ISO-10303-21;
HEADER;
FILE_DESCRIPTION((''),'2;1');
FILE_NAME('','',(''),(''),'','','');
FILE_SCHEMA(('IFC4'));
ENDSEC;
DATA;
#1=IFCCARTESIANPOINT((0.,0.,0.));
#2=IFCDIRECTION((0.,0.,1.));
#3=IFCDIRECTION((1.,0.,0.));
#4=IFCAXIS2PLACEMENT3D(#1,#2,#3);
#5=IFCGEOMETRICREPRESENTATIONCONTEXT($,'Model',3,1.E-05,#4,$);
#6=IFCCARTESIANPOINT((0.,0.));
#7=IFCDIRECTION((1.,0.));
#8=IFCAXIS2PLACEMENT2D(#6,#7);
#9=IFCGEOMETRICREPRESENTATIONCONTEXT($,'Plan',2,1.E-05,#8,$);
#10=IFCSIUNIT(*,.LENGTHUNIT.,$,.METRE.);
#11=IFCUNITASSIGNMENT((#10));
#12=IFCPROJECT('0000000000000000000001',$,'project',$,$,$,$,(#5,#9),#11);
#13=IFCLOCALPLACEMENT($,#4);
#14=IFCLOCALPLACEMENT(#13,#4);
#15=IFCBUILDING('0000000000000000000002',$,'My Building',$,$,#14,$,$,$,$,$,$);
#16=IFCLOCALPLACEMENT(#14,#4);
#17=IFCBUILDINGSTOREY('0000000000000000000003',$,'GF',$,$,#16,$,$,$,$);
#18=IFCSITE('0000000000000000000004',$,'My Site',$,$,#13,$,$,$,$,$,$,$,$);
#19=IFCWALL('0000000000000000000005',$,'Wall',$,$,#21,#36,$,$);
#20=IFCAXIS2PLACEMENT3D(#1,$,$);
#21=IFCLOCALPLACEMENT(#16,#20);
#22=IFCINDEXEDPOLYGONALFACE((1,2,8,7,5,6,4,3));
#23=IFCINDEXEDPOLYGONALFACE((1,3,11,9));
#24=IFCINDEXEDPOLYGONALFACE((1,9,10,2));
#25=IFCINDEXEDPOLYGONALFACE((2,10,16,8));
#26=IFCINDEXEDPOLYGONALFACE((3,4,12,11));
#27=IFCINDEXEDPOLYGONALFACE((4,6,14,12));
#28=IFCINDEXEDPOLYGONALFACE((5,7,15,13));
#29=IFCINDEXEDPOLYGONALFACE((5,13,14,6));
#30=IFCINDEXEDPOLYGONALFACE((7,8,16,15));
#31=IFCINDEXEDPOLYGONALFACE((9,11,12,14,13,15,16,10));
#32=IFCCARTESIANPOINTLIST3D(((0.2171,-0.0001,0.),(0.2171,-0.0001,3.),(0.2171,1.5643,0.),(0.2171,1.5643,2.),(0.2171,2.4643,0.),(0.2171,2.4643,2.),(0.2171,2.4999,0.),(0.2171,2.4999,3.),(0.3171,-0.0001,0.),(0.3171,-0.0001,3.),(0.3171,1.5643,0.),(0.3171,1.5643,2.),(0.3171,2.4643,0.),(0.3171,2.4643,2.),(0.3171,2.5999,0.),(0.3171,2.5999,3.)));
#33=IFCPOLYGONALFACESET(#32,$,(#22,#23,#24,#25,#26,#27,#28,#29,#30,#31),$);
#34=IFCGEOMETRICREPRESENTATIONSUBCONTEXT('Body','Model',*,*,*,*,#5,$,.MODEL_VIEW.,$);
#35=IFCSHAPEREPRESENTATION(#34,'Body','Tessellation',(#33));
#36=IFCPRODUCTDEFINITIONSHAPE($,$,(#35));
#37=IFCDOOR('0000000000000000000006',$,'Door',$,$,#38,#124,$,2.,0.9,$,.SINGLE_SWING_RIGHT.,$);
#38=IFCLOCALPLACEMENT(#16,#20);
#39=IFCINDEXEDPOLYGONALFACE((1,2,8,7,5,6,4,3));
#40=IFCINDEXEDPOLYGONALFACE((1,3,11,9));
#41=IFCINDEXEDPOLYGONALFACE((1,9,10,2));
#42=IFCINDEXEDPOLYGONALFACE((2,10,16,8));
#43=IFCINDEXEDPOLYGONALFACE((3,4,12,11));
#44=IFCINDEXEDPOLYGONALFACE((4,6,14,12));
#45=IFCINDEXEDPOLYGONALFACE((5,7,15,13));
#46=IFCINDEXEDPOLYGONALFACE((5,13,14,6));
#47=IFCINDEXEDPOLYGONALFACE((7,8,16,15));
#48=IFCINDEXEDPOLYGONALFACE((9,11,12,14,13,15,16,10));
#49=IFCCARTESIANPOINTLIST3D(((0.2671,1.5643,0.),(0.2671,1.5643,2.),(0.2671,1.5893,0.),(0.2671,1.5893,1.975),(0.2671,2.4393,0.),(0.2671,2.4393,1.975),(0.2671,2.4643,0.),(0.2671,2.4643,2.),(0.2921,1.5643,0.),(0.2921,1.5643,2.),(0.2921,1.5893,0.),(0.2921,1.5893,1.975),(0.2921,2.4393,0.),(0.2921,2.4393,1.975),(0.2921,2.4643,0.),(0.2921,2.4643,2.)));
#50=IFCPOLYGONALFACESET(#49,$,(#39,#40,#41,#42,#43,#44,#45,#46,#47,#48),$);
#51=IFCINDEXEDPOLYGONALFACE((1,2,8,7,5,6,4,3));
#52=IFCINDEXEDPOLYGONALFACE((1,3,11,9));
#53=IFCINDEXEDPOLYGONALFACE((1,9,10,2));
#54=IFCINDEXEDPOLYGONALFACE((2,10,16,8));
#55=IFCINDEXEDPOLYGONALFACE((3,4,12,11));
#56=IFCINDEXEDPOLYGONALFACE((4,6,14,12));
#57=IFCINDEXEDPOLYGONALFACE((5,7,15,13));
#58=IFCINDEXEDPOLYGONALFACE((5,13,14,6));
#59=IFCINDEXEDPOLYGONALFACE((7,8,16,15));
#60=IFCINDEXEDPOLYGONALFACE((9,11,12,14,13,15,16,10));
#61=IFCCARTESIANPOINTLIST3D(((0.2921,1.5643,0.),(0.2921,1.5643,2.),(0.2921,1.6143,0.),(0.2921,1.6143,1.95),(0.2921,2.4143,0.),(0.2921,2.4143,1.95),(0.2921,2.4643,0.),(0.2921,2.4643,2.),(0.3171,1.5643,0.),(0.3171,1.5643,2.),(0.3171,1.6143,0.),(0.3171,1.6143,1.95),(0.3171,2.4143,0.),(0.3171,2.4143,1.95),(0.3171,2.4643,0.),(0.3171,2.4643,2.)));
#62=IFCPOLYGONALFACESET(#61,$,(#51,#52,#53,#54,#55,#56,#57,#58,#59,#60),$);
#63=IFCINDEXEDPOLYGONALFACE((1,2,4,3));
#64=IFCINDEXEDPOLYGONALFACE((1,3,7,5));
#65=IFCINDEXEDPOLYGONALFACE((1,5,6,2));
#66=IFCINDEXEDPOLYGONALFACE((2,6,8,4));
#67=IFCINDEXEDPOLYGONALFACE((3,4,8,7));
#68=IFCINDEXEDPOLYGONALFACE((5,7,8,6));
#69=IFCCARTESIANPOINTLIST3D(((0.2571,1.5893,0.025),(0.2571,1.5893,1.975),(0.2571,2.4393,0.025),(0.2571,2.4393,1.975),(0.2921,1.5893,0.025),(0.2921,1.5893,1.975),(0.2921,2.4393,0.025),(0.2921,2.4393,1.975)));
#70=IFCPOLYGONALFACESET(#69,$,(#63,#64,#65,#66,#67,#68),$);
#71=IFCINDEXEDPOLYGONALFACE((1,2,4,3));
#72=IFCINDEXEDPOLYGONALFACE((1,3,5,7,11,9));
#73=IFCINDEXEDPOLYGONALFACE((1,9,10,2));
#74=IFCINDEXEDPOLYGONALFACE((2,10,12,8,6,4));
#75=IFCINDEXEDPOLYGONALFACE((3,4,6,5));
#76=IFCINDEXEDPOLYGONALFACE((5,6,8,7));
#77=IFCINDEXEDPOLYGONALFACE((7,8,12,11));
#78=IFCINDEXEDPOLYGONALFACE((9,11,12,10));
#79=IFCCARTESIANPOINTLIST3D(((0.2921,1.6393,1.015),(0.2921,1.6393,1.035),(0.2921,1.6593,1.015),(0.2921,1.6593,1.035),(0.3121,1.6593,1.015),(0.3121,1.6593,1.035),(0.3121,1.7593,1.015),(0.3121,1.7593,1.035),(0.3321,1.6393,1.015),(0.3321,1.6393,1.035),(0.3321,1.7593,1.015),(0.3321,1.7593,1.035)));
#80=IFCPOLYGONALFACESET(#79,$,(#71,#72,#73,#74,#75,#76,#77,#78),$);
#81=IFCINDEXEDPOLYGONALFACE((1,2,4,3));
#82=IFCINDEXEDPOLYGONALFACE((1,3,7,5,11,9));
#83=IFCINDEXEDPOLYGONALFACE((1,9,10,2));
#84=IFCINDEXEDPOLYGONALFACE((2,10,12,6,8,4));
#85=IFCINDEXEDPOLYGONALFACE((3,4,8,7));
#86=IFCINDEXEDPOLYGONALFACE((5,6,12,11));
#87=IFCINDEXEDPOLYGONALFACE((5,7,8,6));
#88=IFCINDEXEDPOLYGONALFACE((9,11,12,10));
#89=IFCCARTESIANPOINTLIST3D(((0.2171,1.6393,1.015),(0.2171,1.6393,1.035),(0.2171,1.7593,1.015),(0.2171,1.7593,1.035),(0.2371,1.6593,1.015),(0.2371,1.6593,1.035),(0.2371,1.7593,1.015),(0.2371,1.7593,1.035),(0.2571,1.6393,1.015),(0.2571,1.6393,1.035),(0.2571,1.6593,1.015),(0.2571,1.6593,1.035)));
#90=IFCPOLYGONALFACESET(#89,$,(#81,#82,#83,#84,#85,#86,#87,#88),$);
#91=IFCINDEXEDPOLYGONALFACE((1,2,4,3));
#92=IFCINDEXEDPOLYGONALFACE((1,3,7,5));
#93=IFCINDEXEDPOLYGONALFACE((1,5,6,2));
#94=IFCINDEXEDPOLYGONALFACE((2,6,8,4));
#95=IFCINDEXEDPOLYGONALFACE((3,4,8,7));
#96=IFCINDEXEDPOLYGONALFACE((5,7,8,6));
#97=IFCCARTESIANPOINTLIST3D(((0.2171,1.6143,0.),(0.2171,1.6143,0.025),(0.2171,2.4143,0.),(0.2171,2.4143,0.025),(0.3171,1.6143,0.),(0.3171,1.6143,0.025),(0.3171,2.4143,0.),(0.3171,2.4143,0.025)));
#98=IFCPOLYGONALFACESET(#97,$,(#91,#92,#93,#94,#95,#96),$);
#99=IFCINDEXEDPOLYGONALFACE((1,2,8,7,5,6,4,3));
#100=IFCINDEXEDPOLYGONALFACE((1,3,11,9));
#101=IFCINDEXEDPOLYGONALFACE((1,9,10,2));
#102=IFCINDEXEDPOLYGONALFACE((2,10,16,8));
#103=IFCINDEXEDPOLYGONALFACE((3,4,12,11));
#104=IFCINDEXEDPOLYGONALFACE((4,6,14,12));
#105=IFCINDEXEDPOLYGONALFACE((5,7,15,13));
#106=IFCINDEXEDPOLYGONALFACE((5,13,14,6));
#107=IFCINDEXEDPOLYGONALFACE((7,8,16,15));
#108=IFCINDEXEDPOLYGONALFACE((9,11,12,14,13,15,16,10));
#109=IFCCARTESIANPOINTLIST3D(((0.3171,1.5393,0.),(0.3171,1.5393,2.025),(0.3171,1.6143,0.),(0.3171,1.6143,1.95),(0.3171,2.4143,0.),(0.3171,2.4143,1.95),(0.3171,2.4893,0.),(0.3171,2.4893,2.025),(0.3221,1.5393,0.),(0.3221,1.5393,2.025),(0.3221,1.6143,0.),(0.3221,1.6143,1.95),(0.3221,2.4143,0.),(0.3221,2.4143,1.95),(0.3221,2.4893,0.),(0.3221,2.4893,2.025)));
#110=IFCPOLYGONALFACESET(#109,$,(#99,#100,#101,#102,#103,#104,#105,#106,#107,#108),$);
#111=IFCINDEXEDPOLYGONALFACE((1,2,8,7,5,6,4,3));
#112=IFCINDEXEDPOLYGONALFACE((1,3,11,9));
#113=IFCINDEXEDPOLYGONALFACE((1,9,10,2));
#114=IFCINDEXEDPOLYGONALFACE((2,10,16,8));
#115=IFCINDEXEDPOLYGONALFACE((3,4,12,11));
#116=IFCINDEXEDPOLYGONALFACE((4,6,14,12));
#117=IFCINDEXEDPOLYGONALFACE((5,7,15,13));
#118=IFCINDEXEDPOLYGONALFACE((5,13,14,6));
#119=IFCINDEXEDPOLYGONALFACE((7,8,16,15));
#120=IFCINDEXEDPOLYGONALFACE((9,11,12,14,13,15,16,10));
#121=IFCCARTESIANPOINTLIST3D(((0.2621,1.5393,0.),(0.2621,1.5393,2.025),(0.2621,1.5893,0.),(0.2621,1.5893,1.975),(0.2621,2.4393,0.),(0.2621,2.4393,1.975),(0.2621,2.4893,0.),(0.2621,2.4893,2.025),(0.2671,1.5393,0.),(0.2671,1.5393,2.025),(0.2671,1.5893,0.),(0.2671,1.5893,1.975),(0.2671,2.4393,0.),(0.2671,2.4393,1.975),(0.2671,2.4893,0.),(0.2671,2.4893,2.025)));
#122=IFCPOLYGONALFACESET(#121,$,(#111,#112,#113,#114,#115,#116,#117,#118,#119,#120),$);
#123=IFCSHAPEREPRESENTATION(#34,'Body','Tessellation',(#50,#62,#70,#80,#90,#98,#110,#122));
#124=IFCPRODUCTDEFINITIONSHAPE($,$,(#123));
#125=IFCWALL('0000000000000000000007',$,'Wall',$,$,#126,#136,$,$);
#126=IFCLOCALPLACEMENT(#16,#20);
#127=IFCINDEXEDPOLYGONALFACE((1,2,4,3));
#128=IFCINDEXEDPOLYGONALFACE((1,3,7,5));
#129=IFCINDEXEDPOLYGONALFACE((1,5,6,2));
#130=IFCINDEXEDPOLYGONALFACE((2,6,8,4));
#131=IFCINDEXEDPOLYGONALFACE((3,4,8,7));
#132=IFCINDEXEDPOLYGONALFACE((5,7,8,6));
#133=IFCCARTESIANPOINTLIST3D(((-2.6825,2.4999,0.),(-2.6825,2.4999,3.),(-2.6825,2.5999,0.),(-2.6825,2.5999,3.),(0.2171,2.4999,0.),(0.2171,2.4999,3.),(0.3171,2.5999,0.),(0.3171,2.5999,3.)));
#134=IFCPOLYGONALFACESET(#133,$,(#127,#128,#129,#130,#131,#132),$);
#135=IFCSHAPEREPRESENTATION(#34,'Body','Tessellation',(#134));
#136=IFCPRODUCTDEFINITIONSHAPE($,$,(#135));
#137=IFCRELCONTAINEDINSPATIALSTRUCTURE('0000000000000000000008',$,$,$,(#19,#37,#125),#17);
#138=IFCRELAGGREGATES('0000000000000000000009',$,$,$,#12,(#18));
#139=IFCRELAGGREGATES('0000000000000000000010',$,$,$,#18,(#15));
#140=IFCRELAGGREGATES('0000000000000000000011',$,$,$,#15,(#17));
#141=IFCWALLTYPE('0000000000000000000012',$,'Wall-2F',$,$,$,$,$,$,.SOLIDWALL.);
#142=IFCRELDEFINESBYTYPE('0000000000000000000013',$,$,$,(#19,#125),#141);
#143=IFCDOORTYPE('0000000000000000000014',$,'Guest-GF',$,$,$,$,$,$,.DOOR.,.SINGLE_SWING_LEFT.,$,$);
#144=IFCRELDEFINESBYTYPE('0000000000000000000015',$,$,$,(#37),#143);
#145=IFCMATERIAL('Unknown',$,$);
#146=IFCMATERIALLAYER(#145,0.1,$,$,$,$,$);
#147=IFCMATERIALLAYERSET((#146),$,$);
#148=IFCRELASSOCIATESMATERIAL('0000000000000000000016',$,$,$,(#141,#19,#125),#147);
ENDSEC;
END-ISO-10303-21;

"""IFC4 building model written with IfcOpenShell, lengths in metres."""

from ifc_helpers import new_model, entity, si_unit, frame, origin_with_axes, origin_2d_with_axis, place, context, subcontext, project, spatial, line, indexed_curve, outline, extrude, shape, source, transform, mapped, material, layer, layer_set, layer_usage, type_object, type_shapes, element, fill, save


model = new_model("IFC4")

# Units and contexts
model_context = context("Model", 3, precision=1e-05, world=origin_with_axes())
plan_context = context("Plan", 2, precision=1e-05, world=origin_2d_with_axis())
body_context_1 = subcontext(model_context, "Body", "Model", "MODEL_VIEW")
body_context_2 = subcontext(plan_context, "Body", "Plan", "PLAN_VIEW")
ifc_project = project(units=[si_unit("LENGTHUNIT", "METRE")], contexts=[model_context, plan_context])

# Site, building, storey
site_placement = place(None, origin_with_axes())
site = spatial("IfcSite", under=ifc_project, at=site_placement, Name="My Site")
building_placement = place(site_placement, origin_with_axes())
building = spatial("IfcBuilding", under=site, at=building_placement, Name="My Building")
storey_placement = place(building_placement, origin_with_axes())
storey = spatial("IfcBuildingStorey", under=building, at=storey_placement, Name="GF")

# Shared definitions
ifc_material_1 = material(Name="Unknown")

# Shared definitions
ifc_layer_1 = layer(ifc_material_1, 0.1)
ifc_layer_set_1 = layer_set([ifc_layer_1])
wall_type = type_object("IfcWallType", Name="Wall-2F", PredefinedType="SOLIDWALL", material=ifc_layer_set_1)

# Wall, opening, door
ifc_layer_usage_1 = layer_usage(ifc_layer_set_1, "AXIS2", "POSITIVE", 0.0)
wall_1_placement = place(storey_placement, frame((0.3171, -0.0001, 0.0), z_axis=(0.0, 0.0, 1.0), x_axis=(0.0, 1.0, 0.0)))
wall_1 = element("IfcWall", 1, at=wall_1_placement, inside=storey, type_object=wall_type, material=ifc_layer_usage_1, Name="Wall", context=body_context_1, shape_type="SweptSolid", body=[
    extrude(outline(indexed_curve([(0.0, 0.0), (0.0, 0.1), (2.5, 0.1), (2.6, 0.0)], segments=[line(1, 2, 3, 4, 1)])), origin_with_axes(), (0.0, 0.0, 1.0), 3.0),
])
shared_shape_1 = source(origin_with_axes(), body_context_1, "Body", "SweptSolid", [
    extrude(outline(indexed_curve([(0.0, 0.0), (0.9, 0.0), (0.9, 2.0), (0.0, 2.0)], segments=[line(1, 2, 3, 4, 1)])), frame((0.0, -0.6, 0.0), z_axis=(0.0, -1.0, 0.0), x_axis=(1.0, 0.0, 0.0)), (0.0, 0.0, -1.0), 1.2),
])
opening_1_placement = place(wall_1_placement, frame((1.5644, 0.0, 0.0), z_axis=(0.0, 0.0, 1.0), x_axis=(1.0, 0.0, 0.0)))
opening_1 = element("IfcOpeningElement", 2, at=opening_1_placement, cuts=wall_1, PredefinedType="OPENING", context=body_context_1, shape_type="MappedRepresentation", body=[
    mapped(shared_shape_1, transform((0.0, 0.0, 0.0), x_axis=(1.0, 0.0, 0.0), y_axis=(0.0, 1.0, 0.0), z_axis=(0.0, 0.0, 1.0), scale=1.0)),
])
door_type_1 = type_object("IfcDoorType", Name="Guest-GF", OperationType="SINGLE_SWING_LEFT", PredefinedType="DOOR")
shared_shape_2 = source(origin_with_axes(), body_context_1, "Body", "SweptSolid", [
    extrude(outline(indexed_curve([(0.0, 0.0), (0.0, 2.0), (0.9, 2.0), (0.9, 0.0), (0.875, 0.0), (0.875, 1.975), (0.025, 1.975), (0.025, 0.0)], segments=[line(1, 2, 3, 4, 5, 6, 7, 8, 1)])), frame((0.0, 0.025, 0.0), z_axis=(0.0, -1.0, 0.0), x_axis=(1.0, 0.0, 0.0)), (0.0, 0.0, -1.0), 0.025),
    extrude(outline(indexed_curve([(0.0, 0.0), (0.0, 2.0), (0.9, 2.0), (0.9, 0.0), (0.85, 0.0), (0.85, 1.95), (0.05, 1.95), (0.05, 0.0)], segments=[line(1, 2, 3, 4, 5, 6, 7, 8, 1)])), frame((0.0, 0.0, 0.0), z_axis=(0.0, -1.0, 0.0), x_axis=(1.0, 0.0, 0.0)), (0.0, 0.0, -1.0), 0.025),
    extrude(outline(indexed_curve([(0.0, 0.0), (0.85, 0.0), (0.85, 0.035), (0.0, 0.035)], segments=[line(1, 2, 3, 4, 1)])), frame((0.025, 0.025, 0.025), z_axis=(0.0, 0.0, 1.0), x_axis=(1.0, 0.0, 0.0)), (0.0, 0.0, 1.0), 1.95),
    extrude(outline(indexed_curve([(0.0, 0.0), (0.0, -0.04), (0.12, -0.04), (0.12, -0.02), (0.02, -0.02), (0.02, 0.0)], segments=[line(1, 2, 3, 4, 5, 6, 1)])), frame((0.075, 0.025, 1.015), z_axis=(0.0, 0.0, 1.0), x_axis=(1.0, 0.0, 0.0)), (0.0, 0.0, 1.0), 0.02),
    extrude(outline(indexed_curve([(0.0, 0.0), (0.0, 0.04), (0.12, 0.04), (0.12, 0.02), (0.02, 0.02), (0.02, 0.0)], segments=[line(1, 2, 3, 4, 5, 6, 1)])), frame((0.075, 0.06, 1.015), z_axis=(0.0, 0.0, 1.0), x_axis=(1.0, 0.0, 0.0)), (0.0, 0.0, 1.0), 0.02),
    extrude(outline(indexed_curve([(0.0, 0.0), (0.8, 0.0), (0.8, 0.1), (0.0, 0.1)], segments=[line(1, 2, 3, 4, 1)])), frame((0.05, 0.0, 0.0), z_axis=(0.0, 0.0, 1.0), x_axis=(1.0, 0.0, 0.0)), (0.0, 0.0, 1.0), 0.025),
    extrude(outline(indexed_curve([(0.0, 0.0), (0.0, 2.025), (0.95, 2.025), (0.95, 0.0), (0.875, 0.0), (0.875, 1.95), (0.075, 1.95), (0.075, 0.0)], segments=[line(1, 2, 3, 4, 5, 6, 7, 8, 1)])), frame((-0.025, -0.005, 0.0), z_axis=(0.0, -1.0, 0.0), x_axis=(1.0, 0.0, 0.0)), (0.0, 0.0, -1.0), 0.005),
    extrude(outline(indexed_curve([(0.0, 0.0), (0.0, 2.025), (0.95, 2.025), (0.95, 0.0), (0.9, 0.0), (0.9, 1.975), (0.05, 1.975), (0.05, 0.0)], segments=[line(1, 2, 3, 4, 5, 6, 7, 8, 1)])), frame((-0.025, 0.05, 0.0), z_axis=(0.0, -1.0, 0.0), x_axis=(1.0, 0.0, 0.0)), (0.0, 0.0, -1.0), 0.005),
])
shared_shape_3 = source(origin_with_axes(), body_context_2, "Body", "Curve2D", [
    entity("IfcIndexedPolyCurve", entity("IfcCartesianPointList2D", [[0.0, 0.0], [0.0, 0.05], [0.025, 0.05], [0.025, 0.025], [0.05, 0.025], [0.05, 0.0]]), [entity("IfcLineIndex", [1, 2, 3, 4, 5, 6, 1])]),
    entity("IfcIndexedPolyCurve", entity("IfcCartesianPointList2D", [[0.9, 0.0], [0.9, 0.05], [0.875, 0.05], [0.875, 0.025], [0.85, 0.025], [0.85, 0.0]]), [entity("IfcLineIndex", [1, 2, 3, 4, 5, 6, 1])]),
    entity("IfcTrimmedCurve", entity("IfcEllipse", entity("IfcAxis2Placement2D", entity("IfcCartesianPoint", [0.84, 0.05]), entity("IfcDirection", [1.0, 0.0])), 0.815, 0.85), [entity("IfcCartesianPoint", [0.84, 0.9])], [entity("IfcCartesianPoint", [0.025, 0.05])], True, "CARTESIAN"),
    entity("IfcIndexedPolyCurve", entity("IfcCartesianPointList2D", [[0.875, 0.05], [0.84, 0.05], [0.84, 0.9], [0.875, 0.9]]), [entity("IfcLineIndex", [1, 2, 3, 4, 1])]),
])
type_shapes(door_type_1, [shared_shape_2, shared_shape_3])
door_1_placement = place(opening_1_placement, frame((0.0, 0.0, 0.0), z_axis=(0.0, 0.0, 1.0), x_axis=(1.0, 0.0, 0.0)))
door_1 = element("IfcDoor", 3, at=door_1_placement, inside=storey, type_object=door_type_1, Name="Door", OperationType="SINGLE_SWING_RIGHT", OverallHeight=2.0, OverallWidth=0.9, shapes=[
    shape(body_context_1, "Body", "MappedRepresentation", [mapped(shared_shape_2, transform((0.0, 0.0, 0.0), x_axis=(1.0, 0.0, 0.0), y_axis=(0.0, 1.0, 0.0), z_axis=(0.0, 0.0, 1.0), scale=1.0))]),
    shape(body_context_2, "Body", "MappedRepresentation", [mapped(shared_shape_3, transform((0.0, 0.0, 0.0), x_axis=(1.0, 0.0, 0.0), y_axis=(0.0, 1.0, 0.0), z_axis=(0.0, 0.0, 1.0), scale=1.0))]),
])
fill(opening_1, door_1)

# Wall
ifc_layer_usage_2 = layer_usage(ifc_layer_set_1, "AXIS2", "POSITIVE", 0.0)
wall_2_placement = place(storey_placement, frame((0.3171, 2.5999, 0.0), z_axis=(0.0, 0.0, 1.0), x_axis=(-1.0, 0.0, 0.0)))
element("IfcWall", 4, at=wall_2_placement, inside=storey, type_object=wall_type, material=ifc_layer_usage_2, Name="Wall", context=body_context_1, shape_type="SweptSolid", body=[
    extrude(outline(indexed_curve([(0.0, 0.0), (0.1, 0.1), (2.9996, 0.1), (2.9996, 0.0)], segments=[line(1, 2, 3, 4, 1)])), origin_with_axes(), (0.0, 0.0, 1.0), 3.0),
])

save(model, "model.ifc")
